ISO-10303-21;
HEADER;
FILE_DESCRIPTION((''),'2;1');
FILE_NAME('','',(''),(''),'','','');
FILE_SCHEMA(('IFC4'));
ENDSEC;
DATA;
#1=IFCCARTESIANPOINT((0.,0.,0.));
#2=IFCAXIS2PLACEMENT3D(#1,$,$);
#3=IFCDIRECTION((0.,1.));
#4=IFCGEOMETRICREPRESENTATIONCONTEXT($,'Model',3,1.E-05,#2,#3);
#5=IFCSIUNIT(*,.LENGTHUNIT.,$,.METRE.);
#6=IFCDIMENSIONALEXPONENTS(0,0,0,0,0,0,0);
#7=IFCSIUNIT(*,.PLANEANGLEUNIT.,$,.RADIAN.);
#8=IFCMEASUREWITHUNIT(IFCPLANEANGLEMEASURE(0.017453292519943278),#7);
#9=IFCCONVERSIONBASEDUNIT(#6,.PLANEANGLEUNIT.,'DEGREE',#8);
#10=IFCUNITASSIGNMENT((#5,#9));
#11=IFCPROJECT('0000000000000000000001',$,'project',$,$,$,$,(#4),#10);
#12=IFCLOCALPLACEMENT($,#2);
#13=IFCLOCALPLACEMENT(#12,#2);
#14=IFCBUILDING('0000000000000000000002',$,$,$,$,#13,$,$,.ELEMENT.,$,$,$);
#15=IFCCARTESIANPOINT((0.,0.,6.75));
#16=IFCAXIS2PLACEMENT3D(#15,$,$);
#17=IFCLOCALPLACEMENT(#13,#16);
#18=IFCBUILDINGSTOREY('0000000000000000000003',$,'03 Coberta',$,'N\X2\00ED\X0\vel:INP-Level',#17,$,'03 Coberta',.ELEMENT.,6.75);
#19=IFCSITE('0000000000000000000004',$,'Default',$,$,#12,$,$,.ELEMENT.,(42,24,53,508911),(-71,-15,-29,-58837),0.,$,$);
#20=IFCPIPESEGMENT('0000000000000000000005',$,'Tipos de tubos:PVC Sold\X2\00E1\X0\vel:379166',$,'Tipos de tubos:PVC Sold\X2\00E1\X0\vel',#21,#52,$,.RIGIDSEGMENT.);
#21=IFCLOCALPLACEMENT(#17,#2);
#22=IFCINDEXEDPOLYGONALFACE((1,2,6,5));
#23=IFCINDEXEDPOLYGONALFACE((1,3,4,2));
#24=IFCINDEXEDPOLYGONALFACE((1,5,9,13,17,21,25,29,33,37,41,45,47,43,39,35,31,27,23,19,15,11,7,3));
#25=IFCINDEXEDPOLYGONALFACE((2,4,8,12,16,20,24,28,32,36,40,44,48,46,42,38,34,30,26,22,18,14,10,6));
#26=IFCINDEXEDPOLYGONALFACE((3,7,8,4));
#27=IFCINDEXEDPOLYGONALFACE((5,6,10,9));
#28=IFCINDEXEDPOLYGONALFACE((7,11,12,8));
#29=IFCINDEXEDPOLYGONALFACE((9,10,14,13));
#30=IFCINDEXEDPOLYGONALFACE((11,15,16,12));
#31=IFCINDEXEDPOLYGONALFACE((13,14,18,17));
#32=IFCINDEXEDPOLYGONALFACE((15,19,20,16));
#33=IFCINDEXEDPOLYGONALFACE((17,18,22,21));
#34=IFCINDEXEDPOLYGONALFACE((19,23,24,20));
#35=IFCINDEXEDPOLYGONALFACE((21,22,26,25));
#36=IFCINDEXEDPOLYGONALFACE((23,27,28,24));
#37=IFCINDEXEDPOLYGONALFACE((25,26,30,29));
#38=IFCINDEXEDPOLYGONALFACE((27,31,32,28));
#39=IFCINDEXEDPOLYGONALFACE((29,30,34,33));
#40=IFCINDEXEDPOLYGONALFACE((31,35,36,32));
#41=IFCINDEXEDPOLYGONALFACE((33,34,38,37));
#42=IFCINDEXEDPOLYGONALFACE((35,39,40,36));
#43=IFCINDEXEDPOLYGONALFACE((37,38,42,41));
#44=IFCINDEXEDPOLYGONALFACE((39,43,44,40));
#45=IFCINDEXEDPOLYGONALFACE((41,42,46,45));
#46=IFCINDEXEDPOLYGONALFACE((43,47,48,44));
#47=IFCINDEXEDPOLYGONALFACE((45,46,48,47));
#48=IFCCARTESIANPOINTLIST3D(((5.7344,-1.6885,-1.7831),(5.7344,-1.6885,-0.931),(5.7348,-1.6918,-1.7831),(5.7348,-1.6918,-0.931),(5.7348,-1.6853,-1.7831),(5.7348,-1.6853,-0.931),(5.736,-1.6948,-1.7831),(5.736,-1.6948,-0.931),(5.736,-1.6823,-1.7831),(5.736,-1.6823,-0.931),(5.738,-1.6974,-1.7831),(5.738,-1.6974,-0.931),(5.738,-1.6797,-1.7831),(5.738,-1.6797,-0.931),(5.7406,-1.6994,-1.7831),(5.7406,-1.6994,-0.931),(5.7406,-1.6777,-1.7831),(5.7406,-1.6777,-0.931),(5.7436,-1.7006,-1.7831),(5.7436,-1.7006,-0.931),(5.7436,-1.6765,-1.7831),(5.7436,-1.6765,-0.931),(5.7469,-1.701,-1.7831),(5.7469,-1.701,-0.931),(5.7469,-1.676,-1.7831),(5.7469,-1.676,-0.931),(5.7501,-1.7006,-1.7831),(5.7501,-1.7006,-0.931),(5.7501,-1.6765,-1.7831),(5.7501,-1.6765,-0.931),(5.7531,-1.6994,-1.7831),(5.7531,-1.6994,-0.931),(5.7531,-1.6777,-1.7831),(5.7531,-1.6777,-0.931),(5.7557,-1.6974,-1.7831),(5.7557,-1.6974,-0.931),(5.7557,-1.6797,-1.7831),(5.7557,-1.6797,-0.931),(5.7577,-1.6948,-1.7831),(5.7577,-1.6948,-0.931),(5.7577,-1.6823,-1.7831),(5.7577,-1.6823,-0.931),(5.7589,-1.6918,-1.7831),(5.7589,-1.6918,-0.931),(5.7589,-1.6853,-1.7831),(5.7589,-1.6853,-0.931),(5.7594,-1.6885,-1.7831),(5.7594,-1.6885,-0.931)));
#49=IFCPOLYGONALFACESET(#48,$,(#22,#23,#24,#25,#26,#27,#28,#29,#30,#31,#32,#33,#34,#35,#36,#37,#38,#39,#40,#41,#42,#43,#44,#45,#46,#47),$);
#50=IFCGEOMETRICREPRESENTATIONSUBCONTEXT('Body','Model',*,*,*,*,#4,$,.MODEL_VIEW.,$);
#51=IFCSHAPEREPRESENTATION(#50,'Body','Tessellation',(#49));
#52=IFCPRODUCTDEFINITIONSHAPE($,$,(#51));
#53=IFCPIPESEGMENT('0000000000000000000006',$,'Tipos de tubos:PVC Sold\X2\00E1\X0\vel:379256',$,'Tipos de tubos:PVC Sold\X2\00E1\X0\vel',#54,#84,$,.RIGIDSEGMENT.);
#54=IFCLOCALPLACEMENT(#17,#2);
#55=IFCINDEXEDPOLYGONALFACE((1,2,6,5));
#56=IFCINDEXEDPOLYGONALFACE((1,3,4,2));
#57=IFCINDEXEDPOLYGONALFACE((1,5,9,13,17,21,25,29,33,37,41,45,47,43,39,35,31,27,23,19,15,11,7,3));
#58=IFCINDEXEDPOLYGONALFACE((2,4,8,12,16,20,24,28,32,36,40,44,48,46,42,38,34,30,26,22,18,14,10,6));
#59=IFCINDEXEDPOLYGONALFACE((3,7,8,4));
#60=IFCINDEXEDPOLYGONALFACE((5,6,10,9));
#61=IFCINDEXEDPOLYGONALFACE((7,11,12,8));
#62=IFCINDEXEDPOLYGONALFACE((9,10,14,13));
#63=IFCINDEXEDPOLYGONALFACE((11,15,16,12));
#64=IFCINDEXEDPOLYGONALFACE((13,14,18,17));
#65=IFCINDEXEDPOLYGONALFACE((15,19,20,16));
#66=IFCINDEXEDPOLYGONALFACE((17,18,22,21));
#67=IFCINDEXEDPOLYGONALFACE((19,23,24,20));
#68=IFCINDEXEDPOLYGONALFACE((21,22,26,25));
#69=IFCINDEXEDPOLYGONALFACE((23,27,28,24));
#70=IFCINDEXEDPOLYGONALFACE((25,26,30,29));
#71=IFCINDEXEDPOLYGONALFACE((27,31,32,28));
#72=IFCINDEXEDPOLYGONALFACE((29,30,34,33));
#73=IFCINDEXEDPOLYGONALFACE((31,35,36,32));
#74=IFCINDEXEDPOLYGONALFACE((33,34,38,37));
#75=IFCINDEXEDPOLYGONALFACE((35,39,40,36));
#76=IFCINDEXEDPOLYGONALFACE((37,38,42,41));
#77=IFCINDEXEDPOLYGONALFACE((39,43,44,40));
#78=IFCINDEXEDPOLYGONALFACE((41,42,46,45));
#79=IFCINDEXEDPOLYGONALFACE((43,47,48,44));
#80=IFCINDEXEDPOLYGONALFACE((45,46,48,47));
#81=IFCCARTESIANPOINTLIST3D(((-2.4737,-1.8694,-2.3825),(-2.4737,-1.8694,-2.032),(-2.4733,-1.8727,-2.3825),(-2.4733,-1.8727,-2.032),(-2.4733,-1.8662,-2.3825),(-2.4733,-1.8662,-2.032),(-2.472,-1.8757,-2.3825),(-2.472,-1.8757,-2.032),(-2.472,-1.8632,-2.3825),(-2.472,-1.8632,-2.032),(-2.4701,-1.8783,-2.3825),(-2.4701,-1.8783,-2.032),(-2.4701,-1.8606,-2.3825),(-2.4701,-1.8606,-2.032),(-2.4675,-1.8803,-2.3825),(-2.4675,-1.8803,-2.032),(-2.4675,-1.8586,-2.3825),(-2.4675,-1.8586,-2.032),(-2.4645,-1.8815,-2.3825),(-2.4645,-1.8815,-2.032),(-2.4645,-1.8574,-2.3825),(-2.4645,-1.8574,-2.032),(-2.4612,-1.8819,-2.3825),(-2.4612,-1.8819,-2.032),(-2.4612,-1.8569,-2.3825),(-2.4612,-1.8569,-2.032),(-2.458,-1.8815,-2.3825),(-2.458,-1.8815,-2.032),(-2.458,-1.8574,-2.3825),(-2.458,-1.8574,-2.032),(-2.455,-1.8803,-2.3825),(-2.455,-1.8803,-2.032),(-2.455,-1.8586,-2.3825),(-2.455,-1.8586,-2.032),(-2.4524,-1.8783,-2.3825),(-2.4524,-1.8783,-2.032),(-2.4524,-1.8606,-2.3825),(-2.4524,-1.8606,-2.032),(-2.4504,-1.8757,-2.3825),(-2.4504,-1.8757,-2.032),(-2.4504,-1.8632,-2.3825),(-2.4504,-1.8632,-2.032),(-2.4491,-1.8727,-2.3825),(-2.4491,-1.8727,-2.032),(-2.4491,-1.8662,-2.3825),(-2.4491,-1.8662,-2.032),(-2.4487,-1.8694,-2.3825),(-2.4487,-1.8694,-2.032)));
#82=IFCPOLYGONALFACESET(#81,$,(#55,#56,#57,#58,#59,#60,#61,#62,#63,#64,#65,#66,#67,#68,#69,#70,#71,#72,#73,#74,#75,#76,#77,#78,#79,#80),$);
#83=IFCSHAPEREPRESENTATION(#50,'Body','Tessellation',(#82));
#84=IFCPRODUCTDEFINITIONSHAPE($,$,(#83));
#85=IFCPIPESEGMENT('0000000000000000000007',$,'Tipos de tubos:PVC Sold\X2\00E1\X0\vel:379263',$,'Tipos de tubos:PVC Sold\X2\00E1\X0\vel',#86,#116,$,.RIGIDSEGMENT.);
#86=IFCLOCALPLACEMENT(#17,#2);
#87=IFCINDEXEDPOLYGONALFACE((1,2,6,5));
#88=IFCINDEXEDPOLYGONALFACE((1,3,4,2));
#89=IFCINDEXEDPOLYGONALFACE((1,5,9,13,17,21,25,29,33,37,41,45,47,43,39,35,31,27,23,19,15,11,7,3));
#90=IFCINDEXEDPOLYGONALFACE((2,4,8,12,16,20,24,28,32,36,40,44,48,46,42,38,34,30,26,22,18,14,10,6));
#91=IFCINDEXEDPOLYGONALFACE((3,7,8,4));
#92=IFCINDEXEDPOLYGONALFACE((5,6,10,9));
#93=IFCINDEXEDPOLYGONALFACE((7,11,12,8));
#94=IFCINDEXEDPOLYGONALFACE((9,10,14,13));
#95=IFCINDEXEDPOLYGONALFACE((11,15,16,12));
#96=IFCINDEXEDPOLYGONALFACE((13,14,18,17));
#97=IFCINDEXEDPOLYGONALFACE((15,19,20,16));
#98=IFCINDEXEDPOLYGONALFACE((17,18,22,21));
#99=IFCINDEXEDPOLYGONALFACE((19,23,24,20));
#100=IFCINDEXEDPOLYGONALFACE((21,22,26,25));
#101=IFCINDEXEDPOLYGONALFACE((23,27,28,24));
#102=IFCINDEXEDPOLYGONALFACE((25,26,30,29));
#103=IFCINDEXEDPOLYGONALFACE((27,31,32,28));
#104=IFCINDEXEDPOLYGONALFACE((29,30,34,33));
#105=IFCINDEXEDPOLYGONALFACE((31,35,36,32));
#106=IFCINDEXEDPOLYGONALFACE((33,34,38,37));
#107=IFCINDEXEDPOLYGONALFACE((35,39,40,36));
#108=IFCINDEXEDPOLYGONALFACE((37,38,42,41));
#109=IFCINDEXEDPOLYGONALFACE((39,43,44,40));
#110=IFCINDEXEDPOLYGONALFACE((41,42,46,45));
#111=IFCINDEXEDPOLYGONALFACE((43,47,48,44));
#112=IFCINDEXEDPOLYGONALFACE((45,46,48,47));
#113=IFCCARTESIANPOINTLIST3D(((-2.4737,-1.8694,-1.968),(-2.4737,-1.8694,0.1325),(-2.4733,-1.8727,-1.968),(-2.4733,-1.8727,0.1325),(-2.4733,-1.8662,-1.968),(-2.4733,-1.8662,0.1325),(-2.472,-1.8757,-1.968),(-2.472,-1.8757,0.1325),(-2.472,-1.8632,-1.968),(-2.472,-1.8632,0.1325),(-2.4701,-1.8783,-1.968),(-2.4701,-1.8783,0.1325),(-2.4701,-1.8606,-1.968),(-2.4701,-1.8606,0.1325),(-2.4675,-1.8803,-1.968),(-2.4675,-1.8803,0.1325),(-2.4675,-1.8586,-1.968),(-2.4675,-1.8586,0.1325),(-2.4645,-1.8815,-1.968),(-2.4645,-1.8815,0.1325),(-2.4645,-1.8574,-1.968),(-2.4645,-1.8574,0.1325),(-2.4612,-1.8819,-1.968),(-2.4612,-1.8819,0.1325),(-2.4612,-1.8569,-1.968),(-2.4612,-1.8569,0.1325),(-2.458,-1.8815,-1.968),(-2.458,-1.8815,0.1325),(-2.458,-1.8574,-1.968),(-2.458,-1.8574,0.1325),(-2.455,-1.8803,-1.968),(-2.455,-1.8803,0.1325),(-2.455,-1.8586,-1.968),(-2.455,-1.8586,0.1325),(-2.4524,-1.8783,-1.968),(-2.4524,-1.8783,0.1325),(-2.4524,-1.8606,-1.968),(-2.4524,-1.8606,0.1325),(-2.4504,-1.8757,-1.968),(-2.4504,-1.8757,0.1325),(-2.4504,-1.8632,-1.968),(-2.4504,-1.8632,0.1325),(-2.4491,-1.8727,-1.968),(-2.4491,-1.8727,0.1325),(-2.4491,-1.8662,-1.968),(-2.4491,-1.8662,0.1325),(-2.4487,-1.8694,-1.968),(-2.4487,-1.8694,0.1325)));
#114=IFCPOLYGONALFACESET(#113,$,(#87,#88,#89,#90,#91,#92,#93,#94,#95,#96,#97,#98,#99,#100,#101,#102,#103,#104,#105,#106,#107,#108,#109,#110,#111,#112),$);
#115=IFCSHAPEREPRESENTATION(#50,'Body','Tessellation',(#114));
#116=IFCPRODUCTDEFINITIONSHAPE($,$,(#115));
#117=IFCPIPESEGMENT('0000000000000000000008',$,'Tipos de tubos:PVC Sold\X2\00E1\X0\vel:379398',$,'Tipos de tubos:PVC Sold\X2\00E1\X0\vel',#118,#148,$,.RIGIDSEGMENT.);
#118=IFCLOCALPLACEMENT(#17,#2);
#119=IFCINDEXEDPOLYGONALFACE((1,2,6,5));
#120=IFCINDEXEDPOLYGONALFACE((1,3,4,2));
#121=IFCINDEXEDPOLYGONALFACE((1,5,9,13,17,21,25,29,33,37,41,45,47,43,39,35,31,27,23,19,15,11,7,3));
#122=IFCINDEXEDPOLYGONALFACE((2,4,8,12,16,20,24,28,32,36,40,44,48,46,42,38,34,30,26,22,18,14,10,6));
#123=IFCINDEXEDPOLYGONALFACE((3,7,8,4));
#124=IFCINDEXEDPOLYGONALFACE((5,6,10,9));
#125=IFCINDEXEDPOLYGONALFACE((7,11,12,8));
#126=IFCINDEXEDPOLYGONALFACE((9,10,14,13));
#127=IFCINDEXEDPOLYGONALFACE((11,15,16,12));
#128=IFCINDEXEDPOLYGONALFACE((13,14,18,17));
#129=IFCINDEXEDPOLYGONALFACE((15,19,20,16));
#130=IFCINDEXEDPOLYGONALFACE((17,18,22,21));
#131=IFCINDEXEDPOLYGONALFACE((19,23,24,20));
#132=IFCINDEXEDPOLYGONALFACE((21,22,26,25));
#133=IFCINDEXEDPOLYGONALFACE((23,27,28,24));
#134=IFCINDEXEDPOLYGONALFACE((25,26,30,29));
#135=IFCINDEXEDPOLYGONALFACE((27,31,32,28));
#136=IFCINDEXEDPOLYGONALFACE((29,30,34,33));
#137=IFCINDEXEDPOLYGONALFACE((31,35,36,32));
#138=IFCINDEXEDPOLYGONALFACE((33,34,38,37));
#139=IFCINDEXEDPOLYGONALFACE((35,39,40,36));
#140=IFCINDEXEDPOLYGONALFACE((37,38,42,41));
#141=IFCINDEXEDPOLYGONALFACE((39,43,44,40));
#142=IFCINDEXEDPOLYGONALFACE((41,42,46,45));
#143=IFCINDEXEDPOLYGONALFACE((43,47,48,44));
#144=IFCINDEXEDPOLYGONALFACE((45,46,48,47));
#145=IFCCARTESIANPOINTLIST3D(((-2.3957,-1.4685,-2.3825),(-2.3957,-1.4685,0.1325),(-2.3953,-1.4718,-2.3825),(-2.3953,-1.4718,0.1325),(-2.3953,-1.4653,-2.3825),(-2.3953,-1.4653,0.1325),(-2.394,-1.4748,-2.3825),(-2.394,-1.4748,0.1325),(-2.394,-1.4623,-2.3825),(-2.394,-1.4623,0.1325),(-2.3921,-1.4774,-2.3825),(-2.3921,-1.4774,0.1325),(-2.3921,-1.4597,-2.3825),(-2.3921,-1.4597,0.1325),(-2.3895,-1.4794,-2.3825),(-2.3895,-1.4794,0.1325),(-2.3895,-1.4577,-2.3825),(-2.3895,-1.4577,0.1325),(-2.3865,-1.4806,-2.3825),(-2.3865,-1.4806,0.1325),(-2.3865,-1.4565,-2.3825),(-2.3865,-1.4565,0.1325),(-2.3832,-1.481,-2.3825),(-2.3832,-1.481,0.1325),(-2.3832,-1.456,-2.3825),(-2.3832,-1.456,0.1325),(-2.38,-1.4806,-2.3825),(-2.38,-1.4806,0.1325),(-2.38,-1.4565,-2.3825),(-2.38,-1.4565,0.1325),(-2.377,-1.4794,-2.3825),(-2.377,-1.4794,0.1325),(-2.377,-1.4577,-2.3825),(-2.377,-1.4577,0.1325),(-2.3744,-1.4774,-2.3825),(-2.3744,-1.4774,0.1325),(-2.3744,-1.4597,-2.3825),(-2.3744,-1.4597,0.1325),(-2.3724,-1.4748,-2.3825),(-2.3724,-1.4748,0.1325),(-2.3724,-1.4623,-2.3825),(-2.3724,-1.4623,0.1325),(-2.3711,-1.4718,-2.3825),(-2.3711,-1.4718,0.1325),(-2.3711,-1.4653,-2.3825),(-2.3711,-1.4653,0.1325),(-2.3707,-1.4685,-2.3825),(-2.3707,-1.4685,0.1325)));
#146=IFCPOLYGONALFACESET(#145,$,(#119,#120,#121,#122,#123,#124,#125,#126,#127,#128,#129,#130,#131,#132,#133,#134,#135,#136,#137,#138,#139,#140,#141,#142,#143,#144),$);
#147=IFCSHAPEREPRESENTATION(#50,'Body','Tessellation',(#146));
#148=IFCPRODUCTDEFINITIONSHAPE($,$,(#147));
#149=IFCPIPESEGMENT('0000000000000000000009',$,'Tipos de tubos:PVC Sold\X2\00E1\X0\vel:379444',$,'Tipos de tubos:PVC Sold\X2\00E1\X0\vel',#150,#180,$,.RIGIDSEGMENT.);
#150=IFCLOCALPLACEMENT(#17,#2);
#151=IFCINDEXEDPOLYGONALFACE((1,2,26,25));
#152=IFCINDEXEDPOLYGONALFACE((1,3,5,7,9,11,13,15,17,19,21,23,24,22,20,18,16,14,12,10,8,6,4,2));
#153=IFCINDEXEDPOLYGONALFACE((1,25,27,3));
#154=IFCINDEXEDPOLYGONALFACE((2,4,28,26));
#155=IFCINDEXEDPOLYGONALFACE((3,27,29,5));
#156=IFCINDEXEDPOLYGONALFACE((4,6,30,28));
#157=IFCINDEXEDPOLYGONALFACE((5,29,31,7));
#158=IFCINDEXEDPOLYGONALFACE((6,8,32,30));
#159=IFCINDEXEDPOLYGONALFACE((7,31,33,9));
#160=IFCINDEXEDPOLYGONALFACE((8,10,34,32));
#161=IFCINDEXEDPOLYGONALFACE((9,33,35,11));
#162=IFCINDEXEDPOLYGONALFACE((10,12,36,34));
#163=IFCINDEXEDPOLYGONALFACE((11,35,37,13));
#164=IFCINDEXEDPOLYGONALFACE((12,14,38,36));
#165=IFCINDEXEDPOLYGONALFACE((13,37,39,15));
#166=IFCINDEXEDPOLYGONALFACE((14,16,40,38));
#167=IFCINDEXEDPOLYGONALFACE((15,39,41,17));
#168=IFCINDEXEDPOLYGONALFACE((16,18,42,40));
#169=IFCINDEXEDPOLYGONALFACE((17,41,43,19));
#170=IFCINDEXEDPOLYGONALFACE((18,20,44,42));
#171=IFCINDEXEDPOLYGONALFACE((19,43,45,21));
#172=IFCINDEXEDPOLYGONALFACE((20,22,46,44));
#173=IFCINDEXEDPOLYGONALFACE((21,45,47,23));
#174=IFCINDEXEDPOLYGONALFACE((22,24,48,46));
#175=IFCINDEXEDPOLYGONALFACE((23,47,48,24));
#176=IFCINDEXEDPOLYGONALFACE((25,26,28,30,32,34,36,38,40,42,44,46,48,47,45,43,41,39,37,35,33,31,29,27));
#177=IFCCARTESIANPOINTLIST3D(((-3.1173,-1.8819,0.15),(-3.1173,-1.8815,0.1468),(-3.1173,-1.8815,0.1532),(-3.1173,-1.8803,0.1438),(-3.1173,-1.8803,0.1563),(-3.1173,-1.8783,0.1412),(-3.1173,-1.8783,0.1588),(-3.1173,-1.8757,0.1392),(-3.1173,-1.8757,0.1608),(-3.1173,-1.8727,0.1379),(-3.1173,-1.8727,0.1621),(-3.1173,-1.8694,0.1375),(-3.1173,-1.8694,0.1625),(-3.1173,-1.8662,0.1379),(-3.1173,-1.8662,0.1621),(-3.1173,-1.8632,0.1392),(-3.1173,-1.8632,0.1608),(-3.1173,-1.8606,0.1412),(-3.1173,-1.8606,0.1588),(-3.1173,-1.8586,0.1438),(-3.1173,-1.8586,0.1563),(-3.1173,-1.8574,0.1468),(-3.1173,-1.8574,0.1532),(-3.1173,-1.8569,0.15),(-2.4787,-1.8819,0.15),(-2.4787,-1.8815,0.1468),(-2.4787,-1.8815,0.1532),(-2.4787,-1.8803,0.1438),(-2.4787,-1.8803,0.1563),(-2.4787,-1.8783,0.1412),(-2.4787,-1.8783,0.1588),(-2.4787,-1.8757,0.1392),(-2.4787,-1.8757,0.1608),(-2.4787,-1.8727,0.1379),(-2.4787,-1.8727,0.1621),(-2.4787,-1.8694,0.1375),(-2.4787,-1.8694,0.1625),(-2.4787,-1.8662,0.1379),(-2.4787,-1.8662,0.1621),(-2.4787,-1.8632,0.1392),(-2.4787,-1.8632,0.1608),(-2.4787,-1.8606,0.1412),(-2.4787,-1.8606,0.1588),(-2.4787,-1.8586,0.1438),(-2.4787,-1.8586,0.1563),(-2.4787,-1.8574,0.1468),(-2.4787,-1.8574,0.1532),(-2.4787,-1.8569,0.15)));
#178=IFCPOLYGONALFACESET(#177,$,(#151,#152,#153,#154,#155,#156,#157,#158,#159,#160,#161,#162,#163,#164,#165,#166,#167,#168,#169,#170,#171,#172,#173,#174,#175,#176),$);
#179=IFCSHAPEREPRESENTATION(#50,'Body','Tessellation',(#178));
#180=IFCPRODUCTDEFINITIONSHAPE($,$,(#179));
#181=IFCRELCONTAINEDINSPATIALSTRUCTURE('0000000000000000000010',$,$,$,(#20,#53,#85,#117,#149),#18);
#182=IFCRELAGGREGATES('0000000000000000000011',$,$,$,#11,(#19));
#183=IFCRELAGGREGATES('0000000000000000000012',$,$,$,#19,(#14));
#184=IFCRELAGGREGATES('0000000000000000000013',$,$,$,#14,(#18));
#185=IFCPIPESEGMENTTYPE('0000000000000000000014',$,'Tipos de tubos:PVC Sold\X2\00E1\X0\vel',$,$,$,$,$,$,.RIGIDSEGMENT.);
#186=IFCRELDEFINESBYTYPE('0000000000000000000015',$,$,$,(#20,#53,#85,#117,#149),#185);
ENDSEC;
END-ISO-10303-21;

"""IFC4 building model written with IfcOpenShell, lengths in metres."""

from ifc_helpers import new_model, entity, si_unit, converted_unit, direction, frame, origin, place, context, subcontext, project, spatial, arc, indexed_curve, outline, extrude, type_object, element, save


model = new_model("IFC4")

# Units and contexts
model_context = context("Model", 3, precision=1e-05, world=origin(), true_north=direction((0.0, 1.0)))
body_context = subcontext(model_context, "Body", "Model", "MODEL_VIEW")
ifc_project = project(units=[si_unit("LENGTHUNIT", "METRE"), converted_unit("PLANEANGLEUNIT", "DEGREE", entity("IfcPlaneAngleMeasure", 0.017453292519943278), si_unit("PLANEANGLEUNIT", "RADIAN"), dimensions=[0, 0, 0, 0, 0, 0, 0])], contexts=[model_context])

# Site, building, storey
site_placement = place(None, origin())
site = spatial("IfcSite", under=ifc_project, at=site_placement, Name="Default", CompositionType="ELEMENT", RefLatitude=(42, 24, 53, 508911), RefLongitude=(-71, -15, -29, -58837), RefElevation=0.0)
building_placement = place(site_placement, origin())
building = spatial("IfcBuilding", under=site, at=building_placement, CompositionType="ELEMENT")
storey_placement = place(building_placement, frame((0.0, 0.0, 6.75)))
storey = spatial("IfcBuildingStorey", under=building, at=storey_placement, Name="03 Coberta", ObjectType="Nível:INP-Level", LongName="03 Coberta", CompositionType="ELEMENT", Elevation=6.75)

# Pipe segments
pipe_segment_type = type_object("IfcPipeSegmentType", Name="Tipos de tubos:PVC Soldável", PredefinedType="RIGIDSEGMENT")
pipe_segment_1_placement = place(storey_placement, origin())
element("IfcPipeSegment", 1, at=pipe_segment_1_placement, inside=storey, type_object=pipe_segment_type, Name="Tipos de tubos:PVC Soldável:379166", ObjectType="Tipos de tubos:PVC Soldável", PredefinedType="RIGIDSEGMENT", context=body_context, shape_type="SweptSolid", body=[
    extrude(outline(indexed_curve([(0.0125, 0.0), (0.0088, 0.0088), (0.0, 0.0125), (-0.0088, 0.0088), (-0.0125, 0.0), (-0.0088, -0.0088), (0.0, -0.0125), (0.0088, -0.0088)], segments=[arc(1, 2, 3), arc(3, 4, 5), arc(5, 6, 7), arc(7, 8, 1)], self_intersect=False)), frame((5.7469, -1.6885, -1.7831), z_axis=(0.0, 0.0, 1.0), x_axis=(-1.0, 0.0, 0.0)), (0.0, 0.0, 1.0), 0.8521),
])
pipe_segment_2_placement = place(storey_placement, origin())
element("IfcPipeSegment", 2, at=pipe_segment_2_placement, inside=storey, type_object=pipe_segment_type, Name="Tipos de tubos:PVC Soldável:379256", ObjectType="Tipos de tubos:PVC Soldável", PredefinedType="RIGIDSEGMENT", context=body_context, shape_type="SweptSolid", body=[
    extrude(outline(indexed_curve([(0.0125, 0.0), (0.0088, 0.0088), (0.0, 0.0125), (-0.0088, 0.0088), (-0.0125, 0.0), (-0.0088, -0.0088), (0.0, -0.0125), (0.0088, -0.0088)], segments=[arc(1, 2, 3), arc(3, 4, 5), arc(5, 6, 7), arc(7, 8, 1)], self_intersect=False)), frame((-2.4612, -1.8694, -2.3825)), (0.0, 0.0, 1.0), 0.3505),
])
pipe_segment_3_placement = place(storey_placement, origin())
element("IfcPipeSegment", 3, at=pipe_segment_3_placement, inside=storey, type_object=pipe_segment_type, Name="Tipos de tubos:PVC Soldável:379263", ObjectType="Tipos de tubos:PVC Soldável", PredefinedType="RIGIDSEGMENT", context=body_context, shape_type="SweptSolid", body=[
    extrude(outline(indexed_curve([(0.0125, 0.0), (0.0088, 0.0088), (0.0, 0.0125), (-0.0088, 0.0088), (-0.0125, 0.0), (-0.0088, -0.0088), (0.0, -0.0125), (0.0088, -0.0088)], segments=[arc(1, 2, 3), arc(3, 4, 5), arc(5, 6, 7), arc(7, 8, 1)], self_intersect=False)), frame((-2.4612, -1.8694, -1.968)), (0.0, 0.0, 1.0), 2.1005),
])
pipe_segment_4_placement = place(storey_placement, origin())
element("IfcPipeSegment", 4, at=pipe_segment_4_placement, inside=storey, type_object=pipe_segment_type, Name="Tipos de tubos:PVC Soldável:379398", ObjectType="Tipos de tubos:PVC Soldável", PredefinedType="RIGIDSEGMENT", context=body_context, shape_type="SweptSolid", body=[
    extrude(outline(indexed_curve([(0.0125, 0.0), (0.0088, 0.0088), (0.0, 0.0125), (-0.0088, 0.0088), (-0.0125, 0.0), (-0.0088, -0.0088), (0.0, -0.0125), (0.0088, -0.0088)], segments=[arc(1, 2, 3), arc(3, 4, 5), arc(5, 6, 7), arc(7, 8, 1)], self_intersect=False)), frame((-2.3832, -1.4685, -2.3825), z_axis=(0.0, 0.0, 1.0), x_axis=(-1.0, 0.0, 0.0)), (0.0, 0.0, 1.0), 2.515),
])
pipe_segment_5_placement = place(storey_placement, origin())
element("IfcPipeSegment", 5, at=pipe_segment_5_placement, inside=storey, type_object=pipe_segment_type, Name="Tipos de tubos:PVC Soldável:379444", ObjectType="Tipos de tubos:PVC Soldável", PredefinedType="RIGIDSEGMENT", context=body_context, shape_type="SweptSolid", body=[
    extrude(outline(indexed_curve([(0.0125, 0.0), (0.0088, 0.0088), (0.0, 0.0125), (-0.0088, 0.0088), (-0.0125, 0.0), (-0.0088, -0.0088), (0.0, -0.0125), (0.0088, -0.0088)], segments=[arc(1, 2, 3), arc(3, 4, 5), arc(5, 6, 7), arc(7, 8, 1)], self_intersect=False)), frame((-3.1173, -1.8694, 0.15), z_axis=(1.0, 0.0, 0.0), x_axis=(0.0, -1.0, 0.0)), (0.0, 0.0, 1.0), 0.6386),
])

save(model, "model.ifc")
